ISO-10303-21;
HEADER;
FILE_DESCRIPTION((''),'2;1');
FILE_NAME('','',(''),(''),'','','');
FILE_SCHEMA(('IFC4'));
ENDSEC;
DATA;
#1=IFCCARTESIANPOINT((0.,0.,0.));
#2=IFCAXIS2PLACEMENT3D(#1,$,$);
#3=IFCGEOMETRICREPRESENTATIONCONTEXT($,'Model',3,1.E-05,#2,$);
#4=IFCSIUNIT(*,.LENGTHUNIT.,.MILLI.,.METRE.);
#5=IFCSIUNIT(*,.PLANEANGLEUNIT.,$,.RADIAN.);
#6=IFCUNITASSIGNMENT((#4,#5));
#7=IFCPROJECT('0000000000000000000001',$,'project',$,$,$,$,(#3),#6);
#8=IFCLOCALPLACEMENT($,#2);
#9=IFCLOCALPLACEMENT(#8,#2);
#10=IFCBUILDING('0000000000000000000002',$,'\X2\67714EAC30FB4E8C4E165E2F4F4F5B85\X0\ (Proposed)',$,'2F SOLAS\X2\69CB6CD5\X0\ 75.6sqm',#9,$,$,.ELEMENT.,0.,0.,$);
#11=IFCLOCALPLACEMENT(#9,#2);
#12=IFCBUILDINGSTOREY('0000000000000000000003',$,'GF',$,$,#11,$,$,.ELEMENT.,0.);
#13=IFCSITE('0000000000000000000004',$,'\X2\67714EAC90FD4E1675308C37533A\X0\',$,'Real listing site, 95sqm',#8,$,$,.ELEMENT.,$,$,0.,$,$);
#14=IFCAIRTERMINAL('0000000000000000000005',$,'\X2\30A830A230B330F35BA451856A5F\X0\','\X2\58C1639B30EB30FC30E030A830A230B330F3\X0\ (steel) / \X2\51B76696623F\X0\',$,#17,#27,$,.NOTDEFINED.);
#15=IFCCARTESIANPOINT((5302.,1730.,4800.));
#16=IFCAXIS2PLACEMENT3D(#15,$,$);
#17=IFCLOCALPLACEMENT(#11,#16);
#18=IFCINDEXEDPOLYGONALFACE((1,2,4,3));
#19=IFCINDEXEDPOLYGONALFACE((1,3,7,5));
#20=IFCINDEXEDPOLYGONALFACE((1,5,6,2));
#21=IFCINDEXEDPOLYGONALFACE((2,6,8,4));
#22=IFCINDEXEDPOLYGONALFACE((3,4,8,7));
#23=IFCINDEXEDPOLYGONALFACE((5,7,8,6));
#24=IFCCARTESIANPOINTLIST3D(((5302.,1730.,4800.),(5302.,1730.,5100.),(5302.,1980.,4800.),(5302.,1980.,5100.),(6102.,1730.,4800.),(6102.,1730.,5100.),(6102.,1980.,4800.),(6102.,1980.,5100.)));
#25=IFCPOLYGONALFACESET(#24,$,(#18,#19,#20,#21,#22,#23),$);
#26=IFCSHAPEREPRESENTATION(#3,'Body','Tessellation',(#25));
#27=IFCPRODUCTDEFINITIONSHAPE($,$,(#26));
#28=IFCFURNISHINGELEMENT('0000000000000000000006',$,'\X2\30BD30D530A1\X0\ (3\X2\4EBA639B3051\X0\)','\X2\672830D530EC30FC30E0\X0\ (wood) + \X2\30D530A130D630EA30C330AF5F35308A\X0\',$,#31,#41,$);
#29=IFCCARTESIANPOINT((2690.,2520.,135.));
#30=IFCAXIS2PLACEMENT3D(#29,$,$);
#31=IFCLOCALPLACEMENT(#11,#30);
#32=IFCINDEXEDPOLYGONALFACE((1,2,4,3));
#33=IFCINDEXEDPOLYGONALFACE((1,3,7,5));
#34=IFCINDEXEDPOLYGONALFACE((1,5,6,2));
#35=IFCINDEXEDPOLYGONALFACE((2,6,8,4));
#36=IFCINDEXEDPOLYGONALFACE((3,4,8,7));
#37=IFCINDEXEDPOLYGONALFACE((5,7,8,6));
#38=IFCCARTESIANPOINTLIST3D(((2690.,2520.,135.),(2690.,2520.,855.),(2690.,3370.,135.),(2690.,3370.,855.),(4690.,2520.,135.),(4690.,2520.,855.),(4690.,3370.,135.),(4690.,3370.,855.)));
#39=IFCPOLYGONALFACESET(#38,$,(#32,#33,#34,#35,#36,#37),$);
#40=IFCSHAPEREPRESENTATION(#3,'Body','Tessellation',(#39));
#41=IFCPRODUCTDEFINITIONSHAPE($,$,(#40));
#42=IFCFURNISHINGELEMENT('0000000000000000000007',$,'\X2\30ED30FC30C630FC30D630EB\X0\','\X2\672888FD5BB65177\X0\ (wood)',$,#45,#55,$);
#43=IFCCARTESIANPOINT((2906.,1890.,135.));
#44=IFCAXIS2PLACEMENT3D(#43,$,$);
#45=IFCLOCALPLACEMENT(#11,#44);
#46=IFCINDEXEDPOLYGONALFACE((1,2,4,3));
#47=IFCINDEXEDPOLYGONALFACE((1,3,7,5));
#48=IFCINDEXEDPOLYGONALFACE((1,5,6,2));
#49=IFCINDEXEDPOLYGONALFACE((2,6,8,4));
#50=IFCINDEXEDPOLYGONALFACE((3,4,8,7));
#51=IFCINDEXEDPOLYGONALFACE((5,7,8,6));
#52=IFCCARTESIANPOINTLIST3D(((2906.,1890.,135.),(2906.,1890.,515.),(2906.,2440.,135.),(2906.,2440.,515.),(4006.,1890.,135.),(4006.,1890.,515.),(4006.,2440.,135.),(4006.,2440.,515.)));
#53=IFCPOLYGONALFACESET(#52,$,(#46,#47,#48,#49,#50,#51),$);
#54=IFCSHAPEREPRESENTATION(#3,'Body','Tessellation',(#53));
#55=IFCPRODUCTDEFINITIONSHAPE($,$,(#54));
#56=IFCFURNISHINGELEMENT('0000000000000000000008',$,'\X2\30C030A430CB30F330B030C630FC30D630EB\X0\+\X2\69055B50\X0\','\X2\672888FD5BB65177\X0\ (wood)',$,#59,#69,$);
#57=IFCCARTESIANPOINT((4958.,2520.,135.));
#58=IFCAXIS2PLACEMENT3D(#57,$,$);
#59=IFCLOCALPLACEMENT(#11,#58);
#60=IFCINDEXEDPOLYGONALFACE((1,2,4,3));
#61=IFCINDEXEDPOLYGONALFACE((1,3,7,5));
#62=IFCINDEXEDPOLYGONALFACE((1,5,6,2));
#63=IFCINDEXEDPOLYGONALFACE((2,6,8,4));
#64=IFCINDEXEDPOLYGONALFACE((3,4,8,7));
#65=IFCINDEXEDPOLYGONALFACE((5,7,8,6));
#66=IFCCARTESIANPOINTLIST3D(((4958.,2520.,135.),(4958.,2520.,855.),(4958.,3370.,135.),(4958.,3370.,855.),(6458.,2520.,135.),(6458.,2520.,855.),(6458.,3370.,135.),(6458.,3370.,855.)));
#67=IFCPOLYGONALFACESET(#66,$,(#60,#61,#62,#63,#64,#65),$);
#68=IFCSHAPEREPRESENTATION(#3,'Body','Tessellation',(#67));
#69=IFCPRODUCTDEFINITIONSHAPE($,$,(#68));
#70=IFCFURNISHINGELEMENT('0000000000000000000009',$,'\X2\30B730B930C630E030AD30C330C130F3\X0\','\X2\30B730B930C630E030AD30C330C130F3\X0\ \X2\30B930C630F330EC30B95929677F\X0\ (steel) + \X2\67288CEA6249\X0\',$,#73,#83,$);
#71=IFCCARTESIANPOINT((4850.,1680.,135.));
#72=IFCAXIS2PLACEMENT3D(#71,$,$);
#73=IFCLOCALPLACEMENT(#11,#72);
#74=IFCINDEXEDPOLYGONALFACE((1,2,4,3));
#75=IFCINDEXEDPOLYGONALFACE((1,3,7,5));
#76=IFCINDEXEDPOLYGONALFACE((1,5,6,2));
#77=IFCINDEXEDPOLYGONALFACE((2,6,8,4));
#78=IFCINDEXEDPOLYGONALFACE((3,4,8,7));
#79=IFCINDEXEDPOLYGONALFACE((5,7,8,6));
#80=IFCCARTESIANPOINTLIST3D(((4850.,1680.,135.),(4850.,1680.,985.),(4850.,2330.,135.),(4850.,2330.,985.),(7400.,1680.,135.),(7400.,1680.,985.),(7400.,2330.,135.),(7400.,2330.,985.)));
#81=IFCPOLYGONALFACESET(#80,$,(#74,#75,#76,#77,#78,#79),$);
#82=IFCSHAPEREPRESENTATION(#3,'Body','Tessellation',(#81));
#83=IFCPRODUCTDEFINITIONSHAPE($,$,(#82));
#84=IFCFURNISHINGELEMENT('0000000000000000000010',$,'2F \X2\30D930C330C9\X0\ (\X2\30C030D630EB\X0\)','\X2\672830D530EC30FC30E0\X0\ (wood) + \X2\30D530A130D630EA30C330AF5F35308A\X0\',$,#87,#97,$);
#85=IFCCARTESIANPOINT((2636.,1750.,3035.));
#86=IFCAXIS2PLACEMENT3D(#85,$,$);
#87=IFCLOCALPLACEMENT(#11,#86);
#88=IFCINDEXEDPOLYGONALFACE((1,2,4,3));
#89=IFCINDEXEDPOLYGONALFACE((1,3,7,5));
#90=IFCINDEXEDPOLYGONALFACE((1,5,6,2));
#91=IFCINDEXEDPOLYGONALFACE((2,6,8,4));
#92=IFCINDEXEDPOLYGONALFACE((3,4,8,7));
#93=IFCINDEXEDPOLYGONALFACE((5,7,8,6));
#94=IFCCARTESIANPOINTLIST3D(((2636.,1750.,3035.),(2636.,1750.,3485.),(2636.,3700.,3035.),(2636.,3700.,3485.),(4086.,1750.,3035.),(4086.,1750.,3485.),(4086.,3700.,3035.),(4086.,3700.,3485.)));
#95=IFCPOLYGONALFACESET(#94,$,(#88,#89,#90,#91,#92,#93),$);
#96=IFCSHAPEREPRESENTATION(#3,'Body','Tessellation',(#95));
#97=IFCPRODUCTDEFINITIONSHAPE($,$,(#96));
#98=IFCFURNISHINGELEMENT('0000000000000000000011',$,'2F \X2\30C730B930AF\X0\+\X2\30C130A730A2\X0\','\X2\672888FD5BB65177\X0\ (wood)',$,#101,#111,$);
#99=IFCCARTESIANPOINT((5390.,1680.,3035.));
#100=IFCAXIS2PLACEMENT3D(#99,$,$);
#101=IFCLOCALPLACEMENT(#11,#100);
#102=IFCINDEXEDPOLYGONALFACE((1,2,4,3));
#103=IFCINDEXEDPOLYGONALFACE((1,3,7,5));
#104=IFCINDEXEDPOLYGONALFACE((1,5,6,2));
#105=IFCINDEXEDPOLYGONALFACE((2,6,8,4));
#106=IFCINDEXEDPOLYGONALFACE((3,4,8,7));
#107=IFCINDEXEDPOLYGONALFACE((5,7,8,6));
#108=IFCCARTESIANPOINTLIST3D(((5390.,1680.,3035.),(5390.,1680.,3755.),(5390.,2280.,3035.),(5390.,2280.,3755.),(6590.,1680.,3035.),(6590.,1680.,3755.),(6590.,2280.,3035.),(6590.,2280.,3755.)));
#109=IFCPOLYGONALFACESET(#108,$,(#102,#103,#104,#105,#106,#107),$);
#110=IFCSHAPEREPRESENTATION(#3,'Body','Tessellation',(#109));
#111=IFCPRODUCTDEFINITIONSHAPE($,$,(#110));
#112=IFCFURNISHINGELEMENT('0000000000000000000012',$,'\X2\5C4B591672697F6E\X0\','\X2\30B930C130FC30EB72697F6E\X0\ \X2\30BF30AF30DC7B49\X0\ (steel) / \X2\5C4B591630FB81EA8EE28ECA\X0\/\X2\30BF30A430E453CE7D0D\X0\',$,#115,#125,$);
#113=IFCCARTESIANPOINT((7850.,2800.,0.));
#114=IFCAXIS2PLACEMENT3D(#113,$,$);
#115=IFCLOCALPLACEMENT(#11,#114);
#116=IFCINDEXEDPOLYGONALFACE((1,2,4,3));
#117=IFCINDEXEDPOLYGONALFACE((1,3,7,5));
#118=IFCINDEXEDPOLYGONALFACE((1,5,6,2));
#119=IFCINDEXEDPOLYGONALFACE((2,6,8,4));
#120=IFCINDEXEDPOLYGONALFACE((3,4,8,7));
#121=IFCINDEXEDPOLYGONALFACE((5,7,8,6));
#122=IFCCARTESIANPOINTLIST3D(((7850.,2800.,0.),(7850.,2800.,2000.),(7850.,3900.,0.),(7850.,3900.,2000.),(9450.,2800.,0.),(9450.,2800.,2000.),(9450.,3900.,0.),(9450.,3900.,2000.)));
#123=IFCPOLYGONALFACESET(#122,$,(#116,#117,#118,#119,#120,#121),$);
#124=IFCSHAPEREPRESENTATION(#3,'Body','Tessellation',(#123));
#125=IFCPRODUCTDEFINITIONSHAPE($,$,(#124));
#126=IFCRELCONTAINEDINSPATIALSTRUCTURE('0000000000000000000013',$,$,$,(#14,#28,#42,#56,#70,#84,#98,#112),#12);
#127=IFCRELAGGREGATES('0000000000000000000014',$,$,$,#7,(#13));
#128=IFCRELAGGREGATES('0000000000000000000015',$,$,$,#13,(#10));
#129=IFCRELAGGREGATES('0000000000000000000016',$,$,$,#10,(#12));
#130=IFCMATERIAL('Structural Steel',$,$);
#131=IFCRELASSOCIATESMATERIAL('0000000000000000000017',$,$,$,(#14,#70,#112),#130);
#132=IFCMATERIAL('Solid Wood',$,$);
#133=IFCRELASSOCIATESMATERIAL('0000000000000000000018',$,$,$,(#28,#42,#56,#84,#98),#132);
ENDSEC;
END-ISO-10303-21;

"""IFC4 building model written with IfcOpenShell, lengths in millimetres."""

from ifc_helpers import new_model, si_unit, frame, frame_2d, origin, place, context, project, spatial, rectangle, extrude, material, element, save


model = new_model("IFC4")

# Units and contexts
model_context = context("Model", 3, precision=1e-05, world=origin())
ifc_project = project(units=[si_unit("LENGTHUNIT", "METRE", prefix="MILLI"), si_unit("PLANEANGLEUNIT", "RADIAN")], contexts=[model_context])

# Site, building, storey
site_placement = place(None, origin())
site = spatial("IfcSite", under=ifc_project, at=site_placement, Name="東京都世田谷区", ObjectType="Real listing site, 95sqm", CompositionType="ELEMENT", RefElevation=0.0)
building_placement = place(site_placement, origin())
building = spatial("IfcBuilding", under=site, at=building_placement, Name="東京・二世帯住宅 (Proposed)", ObjectType="2F SOLAS構法 75.6sqm", CompositionType="ELEMENT", ElevationOfRefHeight=0.0, ElevationOfTerrain=0.0)
storey_placement = place(building_placement, origin())
storey = spatial("IfcBuildingStorey", under=building, at=storey_placement, Name="GF", CompositionType="ELEMENT", Elevation=0.0)

# Shared definitions
ifc_material_1 = material(Name="Solid Wood")

# Shared definitions
ifc_material_2 = material(Name="Structural Steel")

# Air terminal
air_terminal_1_placement = place(storey_placement, frame((5302.0, 1730.0, 4800.0)))
element("IfcAirTerminal", 1, at=air_terminal_1_placement, inside=storey, material=ifc_material_2, Name="エアコン室内機", Description="壁掛ルームエアコン (steel) / 冷暖房", PredefinedType="NOTDEFINED", context=model_context, shape_type="SweptSolid", body=[
    extrude(rectangle(XDim=800.0, YDim=250.0, at=frame_2d((400.0, 125.0))), frame((5302.0, 1730.0, 4800.0)), (0.0, 0.0, 1.0), 300.0),
])

# Furnishing elements
furnishing_1_placement = place(storey_placement, frame((2690.0, 2520.0, 135.0)))
element("IfcFurnishingElement", 2, at=furnishing_1_placement, inside=storey, material=ifc_material_1, Name="ソファ (3人掛け)", Description="木フレーム (wood) + ファブリック張り", context=model_context, shape_type="SweptSolid", body=[
    extrude(rectangle(XDim=2000.0, YDim=850.0, at=frame_2d((1000.0, 425.0))), frame((2690.0, 2520.0, 135.0)), (0.0, 0.0, 1.0), 720.0),
])
furnishing_2_placement = place(storey_placement, frame((2906.0, 1890.0, 135.0)))
element("IfcFurnishingElement", 3, at=furnishing_2_placement, inside=storey, material=ifc_material_1, Name="ローテーブル", Description="木製家具 (wood)", context=model_context, shape_type="SweptSolid", body=[
    extrude(rectangle(XDim=1100.0, YDim=550.0, at=frame_2d((550.0, 275.0))), frame((2906.0, 1890.0, 135.0)), (0.0, 0.0, 1.0), 380.0),
])
furnishing_3_placement = place(storey_placement, frame((4958.0, 2520.0, 135.0)))
element("IfcFurnishingElement", 4, at=furnishing_3_placement, inside=storey, material=ifc_material_1, Name="ダイニングテーブル+椅子", Description="木製家具 (wood)", context=model_context, shape_type="SweptSolid", body=[
    extrude(rectangle(XDim=1500.0, YDim=850.0, at=frame_2d((750.0, 425.0))), frame((4958.0, 2520.0, 135.0)), (0.0, 0.0, 1.0), 720.0),
])
furnishing_4_placement = place(storey_placement, frame((4850.0, 1680.0, 135.0)))
element("IfcFurnishingElement", 5, at=furnishing_4_placement, inside=storey, material=ifc_material_2, Name="システムキッチン", Description="システムキッチン ステンレス天板 (steel) + 木質扉", context=model_context, shape_type="SweptSolid", body=[
    extrude(rectangle(XDim=2550.0, YDim=650.0, at=frame_2d((1275.0, 325.0))), frame((4850.0, 1680.0, 135.0)), (0.0, 0.0, 1.0), 850.0),
])
furnishing_5_placement = place(storey_placement, frame((2636.0, 1750.0, 3035.0)))
element("IfcFurnishingElement", 6, at=furnishing_5_placement, inside=storey, material=ifc_material_1, Name="2F ベッド (ダブル)", Description="木フレーム (wood) + ファブリック張り", context=model_context, shape_type="SweptSolid", body=[
    extrude(rectangle(XDim=1450.0, YDim=1950.0, at=frame_2d((725.0, 975.0))), frame((2636.0, 1750.0, 3035.0)), (0.0, 0.0, 1.0), 450.0),
])
furnishing_6_placement = place(storey_placement, frame((5390.0, 1680.0, 3035.0)))
element("IfcFurnishingElement", 7, at=furnishing_6_placement, inside=storey, material=ifc_material_1, Name="2F デスク+チェア", Description="木製家具 (wood)", context=model_context, shape_type="SweptSolid", body=[
    extrude(rectangle(XDim=1200.0, YDim=600.0, at=frame_2d((600.0, 300.0))), frame((5390.0, 1680.0, 3035.0)), (0.0, 0.0, 1.0), 720.0),
])
furnishing_7_placement = place(storey_placement, frame((7850.0, 2800.0, 0.0)))
element("IfcFurnishingElement", 8, at=furnishing_7_placement, inside=storey, material=ifc_material_2, Name="屋外物置", Description="スチール物置 タクボ等 (steel) / 屋外・自転車/タイヤ収納", context=model_context, shape_type="SweptSolid", body=[
    extrude(rectangle(XDim=1600.0, YDim=1100.0, at=frame_2d((800.0, 550.0))), frame((7850.0, 2800.0, 0.0)), (0.0, 0.0, 1.0), 2000.0),
])

save(model, "model.ifc")
